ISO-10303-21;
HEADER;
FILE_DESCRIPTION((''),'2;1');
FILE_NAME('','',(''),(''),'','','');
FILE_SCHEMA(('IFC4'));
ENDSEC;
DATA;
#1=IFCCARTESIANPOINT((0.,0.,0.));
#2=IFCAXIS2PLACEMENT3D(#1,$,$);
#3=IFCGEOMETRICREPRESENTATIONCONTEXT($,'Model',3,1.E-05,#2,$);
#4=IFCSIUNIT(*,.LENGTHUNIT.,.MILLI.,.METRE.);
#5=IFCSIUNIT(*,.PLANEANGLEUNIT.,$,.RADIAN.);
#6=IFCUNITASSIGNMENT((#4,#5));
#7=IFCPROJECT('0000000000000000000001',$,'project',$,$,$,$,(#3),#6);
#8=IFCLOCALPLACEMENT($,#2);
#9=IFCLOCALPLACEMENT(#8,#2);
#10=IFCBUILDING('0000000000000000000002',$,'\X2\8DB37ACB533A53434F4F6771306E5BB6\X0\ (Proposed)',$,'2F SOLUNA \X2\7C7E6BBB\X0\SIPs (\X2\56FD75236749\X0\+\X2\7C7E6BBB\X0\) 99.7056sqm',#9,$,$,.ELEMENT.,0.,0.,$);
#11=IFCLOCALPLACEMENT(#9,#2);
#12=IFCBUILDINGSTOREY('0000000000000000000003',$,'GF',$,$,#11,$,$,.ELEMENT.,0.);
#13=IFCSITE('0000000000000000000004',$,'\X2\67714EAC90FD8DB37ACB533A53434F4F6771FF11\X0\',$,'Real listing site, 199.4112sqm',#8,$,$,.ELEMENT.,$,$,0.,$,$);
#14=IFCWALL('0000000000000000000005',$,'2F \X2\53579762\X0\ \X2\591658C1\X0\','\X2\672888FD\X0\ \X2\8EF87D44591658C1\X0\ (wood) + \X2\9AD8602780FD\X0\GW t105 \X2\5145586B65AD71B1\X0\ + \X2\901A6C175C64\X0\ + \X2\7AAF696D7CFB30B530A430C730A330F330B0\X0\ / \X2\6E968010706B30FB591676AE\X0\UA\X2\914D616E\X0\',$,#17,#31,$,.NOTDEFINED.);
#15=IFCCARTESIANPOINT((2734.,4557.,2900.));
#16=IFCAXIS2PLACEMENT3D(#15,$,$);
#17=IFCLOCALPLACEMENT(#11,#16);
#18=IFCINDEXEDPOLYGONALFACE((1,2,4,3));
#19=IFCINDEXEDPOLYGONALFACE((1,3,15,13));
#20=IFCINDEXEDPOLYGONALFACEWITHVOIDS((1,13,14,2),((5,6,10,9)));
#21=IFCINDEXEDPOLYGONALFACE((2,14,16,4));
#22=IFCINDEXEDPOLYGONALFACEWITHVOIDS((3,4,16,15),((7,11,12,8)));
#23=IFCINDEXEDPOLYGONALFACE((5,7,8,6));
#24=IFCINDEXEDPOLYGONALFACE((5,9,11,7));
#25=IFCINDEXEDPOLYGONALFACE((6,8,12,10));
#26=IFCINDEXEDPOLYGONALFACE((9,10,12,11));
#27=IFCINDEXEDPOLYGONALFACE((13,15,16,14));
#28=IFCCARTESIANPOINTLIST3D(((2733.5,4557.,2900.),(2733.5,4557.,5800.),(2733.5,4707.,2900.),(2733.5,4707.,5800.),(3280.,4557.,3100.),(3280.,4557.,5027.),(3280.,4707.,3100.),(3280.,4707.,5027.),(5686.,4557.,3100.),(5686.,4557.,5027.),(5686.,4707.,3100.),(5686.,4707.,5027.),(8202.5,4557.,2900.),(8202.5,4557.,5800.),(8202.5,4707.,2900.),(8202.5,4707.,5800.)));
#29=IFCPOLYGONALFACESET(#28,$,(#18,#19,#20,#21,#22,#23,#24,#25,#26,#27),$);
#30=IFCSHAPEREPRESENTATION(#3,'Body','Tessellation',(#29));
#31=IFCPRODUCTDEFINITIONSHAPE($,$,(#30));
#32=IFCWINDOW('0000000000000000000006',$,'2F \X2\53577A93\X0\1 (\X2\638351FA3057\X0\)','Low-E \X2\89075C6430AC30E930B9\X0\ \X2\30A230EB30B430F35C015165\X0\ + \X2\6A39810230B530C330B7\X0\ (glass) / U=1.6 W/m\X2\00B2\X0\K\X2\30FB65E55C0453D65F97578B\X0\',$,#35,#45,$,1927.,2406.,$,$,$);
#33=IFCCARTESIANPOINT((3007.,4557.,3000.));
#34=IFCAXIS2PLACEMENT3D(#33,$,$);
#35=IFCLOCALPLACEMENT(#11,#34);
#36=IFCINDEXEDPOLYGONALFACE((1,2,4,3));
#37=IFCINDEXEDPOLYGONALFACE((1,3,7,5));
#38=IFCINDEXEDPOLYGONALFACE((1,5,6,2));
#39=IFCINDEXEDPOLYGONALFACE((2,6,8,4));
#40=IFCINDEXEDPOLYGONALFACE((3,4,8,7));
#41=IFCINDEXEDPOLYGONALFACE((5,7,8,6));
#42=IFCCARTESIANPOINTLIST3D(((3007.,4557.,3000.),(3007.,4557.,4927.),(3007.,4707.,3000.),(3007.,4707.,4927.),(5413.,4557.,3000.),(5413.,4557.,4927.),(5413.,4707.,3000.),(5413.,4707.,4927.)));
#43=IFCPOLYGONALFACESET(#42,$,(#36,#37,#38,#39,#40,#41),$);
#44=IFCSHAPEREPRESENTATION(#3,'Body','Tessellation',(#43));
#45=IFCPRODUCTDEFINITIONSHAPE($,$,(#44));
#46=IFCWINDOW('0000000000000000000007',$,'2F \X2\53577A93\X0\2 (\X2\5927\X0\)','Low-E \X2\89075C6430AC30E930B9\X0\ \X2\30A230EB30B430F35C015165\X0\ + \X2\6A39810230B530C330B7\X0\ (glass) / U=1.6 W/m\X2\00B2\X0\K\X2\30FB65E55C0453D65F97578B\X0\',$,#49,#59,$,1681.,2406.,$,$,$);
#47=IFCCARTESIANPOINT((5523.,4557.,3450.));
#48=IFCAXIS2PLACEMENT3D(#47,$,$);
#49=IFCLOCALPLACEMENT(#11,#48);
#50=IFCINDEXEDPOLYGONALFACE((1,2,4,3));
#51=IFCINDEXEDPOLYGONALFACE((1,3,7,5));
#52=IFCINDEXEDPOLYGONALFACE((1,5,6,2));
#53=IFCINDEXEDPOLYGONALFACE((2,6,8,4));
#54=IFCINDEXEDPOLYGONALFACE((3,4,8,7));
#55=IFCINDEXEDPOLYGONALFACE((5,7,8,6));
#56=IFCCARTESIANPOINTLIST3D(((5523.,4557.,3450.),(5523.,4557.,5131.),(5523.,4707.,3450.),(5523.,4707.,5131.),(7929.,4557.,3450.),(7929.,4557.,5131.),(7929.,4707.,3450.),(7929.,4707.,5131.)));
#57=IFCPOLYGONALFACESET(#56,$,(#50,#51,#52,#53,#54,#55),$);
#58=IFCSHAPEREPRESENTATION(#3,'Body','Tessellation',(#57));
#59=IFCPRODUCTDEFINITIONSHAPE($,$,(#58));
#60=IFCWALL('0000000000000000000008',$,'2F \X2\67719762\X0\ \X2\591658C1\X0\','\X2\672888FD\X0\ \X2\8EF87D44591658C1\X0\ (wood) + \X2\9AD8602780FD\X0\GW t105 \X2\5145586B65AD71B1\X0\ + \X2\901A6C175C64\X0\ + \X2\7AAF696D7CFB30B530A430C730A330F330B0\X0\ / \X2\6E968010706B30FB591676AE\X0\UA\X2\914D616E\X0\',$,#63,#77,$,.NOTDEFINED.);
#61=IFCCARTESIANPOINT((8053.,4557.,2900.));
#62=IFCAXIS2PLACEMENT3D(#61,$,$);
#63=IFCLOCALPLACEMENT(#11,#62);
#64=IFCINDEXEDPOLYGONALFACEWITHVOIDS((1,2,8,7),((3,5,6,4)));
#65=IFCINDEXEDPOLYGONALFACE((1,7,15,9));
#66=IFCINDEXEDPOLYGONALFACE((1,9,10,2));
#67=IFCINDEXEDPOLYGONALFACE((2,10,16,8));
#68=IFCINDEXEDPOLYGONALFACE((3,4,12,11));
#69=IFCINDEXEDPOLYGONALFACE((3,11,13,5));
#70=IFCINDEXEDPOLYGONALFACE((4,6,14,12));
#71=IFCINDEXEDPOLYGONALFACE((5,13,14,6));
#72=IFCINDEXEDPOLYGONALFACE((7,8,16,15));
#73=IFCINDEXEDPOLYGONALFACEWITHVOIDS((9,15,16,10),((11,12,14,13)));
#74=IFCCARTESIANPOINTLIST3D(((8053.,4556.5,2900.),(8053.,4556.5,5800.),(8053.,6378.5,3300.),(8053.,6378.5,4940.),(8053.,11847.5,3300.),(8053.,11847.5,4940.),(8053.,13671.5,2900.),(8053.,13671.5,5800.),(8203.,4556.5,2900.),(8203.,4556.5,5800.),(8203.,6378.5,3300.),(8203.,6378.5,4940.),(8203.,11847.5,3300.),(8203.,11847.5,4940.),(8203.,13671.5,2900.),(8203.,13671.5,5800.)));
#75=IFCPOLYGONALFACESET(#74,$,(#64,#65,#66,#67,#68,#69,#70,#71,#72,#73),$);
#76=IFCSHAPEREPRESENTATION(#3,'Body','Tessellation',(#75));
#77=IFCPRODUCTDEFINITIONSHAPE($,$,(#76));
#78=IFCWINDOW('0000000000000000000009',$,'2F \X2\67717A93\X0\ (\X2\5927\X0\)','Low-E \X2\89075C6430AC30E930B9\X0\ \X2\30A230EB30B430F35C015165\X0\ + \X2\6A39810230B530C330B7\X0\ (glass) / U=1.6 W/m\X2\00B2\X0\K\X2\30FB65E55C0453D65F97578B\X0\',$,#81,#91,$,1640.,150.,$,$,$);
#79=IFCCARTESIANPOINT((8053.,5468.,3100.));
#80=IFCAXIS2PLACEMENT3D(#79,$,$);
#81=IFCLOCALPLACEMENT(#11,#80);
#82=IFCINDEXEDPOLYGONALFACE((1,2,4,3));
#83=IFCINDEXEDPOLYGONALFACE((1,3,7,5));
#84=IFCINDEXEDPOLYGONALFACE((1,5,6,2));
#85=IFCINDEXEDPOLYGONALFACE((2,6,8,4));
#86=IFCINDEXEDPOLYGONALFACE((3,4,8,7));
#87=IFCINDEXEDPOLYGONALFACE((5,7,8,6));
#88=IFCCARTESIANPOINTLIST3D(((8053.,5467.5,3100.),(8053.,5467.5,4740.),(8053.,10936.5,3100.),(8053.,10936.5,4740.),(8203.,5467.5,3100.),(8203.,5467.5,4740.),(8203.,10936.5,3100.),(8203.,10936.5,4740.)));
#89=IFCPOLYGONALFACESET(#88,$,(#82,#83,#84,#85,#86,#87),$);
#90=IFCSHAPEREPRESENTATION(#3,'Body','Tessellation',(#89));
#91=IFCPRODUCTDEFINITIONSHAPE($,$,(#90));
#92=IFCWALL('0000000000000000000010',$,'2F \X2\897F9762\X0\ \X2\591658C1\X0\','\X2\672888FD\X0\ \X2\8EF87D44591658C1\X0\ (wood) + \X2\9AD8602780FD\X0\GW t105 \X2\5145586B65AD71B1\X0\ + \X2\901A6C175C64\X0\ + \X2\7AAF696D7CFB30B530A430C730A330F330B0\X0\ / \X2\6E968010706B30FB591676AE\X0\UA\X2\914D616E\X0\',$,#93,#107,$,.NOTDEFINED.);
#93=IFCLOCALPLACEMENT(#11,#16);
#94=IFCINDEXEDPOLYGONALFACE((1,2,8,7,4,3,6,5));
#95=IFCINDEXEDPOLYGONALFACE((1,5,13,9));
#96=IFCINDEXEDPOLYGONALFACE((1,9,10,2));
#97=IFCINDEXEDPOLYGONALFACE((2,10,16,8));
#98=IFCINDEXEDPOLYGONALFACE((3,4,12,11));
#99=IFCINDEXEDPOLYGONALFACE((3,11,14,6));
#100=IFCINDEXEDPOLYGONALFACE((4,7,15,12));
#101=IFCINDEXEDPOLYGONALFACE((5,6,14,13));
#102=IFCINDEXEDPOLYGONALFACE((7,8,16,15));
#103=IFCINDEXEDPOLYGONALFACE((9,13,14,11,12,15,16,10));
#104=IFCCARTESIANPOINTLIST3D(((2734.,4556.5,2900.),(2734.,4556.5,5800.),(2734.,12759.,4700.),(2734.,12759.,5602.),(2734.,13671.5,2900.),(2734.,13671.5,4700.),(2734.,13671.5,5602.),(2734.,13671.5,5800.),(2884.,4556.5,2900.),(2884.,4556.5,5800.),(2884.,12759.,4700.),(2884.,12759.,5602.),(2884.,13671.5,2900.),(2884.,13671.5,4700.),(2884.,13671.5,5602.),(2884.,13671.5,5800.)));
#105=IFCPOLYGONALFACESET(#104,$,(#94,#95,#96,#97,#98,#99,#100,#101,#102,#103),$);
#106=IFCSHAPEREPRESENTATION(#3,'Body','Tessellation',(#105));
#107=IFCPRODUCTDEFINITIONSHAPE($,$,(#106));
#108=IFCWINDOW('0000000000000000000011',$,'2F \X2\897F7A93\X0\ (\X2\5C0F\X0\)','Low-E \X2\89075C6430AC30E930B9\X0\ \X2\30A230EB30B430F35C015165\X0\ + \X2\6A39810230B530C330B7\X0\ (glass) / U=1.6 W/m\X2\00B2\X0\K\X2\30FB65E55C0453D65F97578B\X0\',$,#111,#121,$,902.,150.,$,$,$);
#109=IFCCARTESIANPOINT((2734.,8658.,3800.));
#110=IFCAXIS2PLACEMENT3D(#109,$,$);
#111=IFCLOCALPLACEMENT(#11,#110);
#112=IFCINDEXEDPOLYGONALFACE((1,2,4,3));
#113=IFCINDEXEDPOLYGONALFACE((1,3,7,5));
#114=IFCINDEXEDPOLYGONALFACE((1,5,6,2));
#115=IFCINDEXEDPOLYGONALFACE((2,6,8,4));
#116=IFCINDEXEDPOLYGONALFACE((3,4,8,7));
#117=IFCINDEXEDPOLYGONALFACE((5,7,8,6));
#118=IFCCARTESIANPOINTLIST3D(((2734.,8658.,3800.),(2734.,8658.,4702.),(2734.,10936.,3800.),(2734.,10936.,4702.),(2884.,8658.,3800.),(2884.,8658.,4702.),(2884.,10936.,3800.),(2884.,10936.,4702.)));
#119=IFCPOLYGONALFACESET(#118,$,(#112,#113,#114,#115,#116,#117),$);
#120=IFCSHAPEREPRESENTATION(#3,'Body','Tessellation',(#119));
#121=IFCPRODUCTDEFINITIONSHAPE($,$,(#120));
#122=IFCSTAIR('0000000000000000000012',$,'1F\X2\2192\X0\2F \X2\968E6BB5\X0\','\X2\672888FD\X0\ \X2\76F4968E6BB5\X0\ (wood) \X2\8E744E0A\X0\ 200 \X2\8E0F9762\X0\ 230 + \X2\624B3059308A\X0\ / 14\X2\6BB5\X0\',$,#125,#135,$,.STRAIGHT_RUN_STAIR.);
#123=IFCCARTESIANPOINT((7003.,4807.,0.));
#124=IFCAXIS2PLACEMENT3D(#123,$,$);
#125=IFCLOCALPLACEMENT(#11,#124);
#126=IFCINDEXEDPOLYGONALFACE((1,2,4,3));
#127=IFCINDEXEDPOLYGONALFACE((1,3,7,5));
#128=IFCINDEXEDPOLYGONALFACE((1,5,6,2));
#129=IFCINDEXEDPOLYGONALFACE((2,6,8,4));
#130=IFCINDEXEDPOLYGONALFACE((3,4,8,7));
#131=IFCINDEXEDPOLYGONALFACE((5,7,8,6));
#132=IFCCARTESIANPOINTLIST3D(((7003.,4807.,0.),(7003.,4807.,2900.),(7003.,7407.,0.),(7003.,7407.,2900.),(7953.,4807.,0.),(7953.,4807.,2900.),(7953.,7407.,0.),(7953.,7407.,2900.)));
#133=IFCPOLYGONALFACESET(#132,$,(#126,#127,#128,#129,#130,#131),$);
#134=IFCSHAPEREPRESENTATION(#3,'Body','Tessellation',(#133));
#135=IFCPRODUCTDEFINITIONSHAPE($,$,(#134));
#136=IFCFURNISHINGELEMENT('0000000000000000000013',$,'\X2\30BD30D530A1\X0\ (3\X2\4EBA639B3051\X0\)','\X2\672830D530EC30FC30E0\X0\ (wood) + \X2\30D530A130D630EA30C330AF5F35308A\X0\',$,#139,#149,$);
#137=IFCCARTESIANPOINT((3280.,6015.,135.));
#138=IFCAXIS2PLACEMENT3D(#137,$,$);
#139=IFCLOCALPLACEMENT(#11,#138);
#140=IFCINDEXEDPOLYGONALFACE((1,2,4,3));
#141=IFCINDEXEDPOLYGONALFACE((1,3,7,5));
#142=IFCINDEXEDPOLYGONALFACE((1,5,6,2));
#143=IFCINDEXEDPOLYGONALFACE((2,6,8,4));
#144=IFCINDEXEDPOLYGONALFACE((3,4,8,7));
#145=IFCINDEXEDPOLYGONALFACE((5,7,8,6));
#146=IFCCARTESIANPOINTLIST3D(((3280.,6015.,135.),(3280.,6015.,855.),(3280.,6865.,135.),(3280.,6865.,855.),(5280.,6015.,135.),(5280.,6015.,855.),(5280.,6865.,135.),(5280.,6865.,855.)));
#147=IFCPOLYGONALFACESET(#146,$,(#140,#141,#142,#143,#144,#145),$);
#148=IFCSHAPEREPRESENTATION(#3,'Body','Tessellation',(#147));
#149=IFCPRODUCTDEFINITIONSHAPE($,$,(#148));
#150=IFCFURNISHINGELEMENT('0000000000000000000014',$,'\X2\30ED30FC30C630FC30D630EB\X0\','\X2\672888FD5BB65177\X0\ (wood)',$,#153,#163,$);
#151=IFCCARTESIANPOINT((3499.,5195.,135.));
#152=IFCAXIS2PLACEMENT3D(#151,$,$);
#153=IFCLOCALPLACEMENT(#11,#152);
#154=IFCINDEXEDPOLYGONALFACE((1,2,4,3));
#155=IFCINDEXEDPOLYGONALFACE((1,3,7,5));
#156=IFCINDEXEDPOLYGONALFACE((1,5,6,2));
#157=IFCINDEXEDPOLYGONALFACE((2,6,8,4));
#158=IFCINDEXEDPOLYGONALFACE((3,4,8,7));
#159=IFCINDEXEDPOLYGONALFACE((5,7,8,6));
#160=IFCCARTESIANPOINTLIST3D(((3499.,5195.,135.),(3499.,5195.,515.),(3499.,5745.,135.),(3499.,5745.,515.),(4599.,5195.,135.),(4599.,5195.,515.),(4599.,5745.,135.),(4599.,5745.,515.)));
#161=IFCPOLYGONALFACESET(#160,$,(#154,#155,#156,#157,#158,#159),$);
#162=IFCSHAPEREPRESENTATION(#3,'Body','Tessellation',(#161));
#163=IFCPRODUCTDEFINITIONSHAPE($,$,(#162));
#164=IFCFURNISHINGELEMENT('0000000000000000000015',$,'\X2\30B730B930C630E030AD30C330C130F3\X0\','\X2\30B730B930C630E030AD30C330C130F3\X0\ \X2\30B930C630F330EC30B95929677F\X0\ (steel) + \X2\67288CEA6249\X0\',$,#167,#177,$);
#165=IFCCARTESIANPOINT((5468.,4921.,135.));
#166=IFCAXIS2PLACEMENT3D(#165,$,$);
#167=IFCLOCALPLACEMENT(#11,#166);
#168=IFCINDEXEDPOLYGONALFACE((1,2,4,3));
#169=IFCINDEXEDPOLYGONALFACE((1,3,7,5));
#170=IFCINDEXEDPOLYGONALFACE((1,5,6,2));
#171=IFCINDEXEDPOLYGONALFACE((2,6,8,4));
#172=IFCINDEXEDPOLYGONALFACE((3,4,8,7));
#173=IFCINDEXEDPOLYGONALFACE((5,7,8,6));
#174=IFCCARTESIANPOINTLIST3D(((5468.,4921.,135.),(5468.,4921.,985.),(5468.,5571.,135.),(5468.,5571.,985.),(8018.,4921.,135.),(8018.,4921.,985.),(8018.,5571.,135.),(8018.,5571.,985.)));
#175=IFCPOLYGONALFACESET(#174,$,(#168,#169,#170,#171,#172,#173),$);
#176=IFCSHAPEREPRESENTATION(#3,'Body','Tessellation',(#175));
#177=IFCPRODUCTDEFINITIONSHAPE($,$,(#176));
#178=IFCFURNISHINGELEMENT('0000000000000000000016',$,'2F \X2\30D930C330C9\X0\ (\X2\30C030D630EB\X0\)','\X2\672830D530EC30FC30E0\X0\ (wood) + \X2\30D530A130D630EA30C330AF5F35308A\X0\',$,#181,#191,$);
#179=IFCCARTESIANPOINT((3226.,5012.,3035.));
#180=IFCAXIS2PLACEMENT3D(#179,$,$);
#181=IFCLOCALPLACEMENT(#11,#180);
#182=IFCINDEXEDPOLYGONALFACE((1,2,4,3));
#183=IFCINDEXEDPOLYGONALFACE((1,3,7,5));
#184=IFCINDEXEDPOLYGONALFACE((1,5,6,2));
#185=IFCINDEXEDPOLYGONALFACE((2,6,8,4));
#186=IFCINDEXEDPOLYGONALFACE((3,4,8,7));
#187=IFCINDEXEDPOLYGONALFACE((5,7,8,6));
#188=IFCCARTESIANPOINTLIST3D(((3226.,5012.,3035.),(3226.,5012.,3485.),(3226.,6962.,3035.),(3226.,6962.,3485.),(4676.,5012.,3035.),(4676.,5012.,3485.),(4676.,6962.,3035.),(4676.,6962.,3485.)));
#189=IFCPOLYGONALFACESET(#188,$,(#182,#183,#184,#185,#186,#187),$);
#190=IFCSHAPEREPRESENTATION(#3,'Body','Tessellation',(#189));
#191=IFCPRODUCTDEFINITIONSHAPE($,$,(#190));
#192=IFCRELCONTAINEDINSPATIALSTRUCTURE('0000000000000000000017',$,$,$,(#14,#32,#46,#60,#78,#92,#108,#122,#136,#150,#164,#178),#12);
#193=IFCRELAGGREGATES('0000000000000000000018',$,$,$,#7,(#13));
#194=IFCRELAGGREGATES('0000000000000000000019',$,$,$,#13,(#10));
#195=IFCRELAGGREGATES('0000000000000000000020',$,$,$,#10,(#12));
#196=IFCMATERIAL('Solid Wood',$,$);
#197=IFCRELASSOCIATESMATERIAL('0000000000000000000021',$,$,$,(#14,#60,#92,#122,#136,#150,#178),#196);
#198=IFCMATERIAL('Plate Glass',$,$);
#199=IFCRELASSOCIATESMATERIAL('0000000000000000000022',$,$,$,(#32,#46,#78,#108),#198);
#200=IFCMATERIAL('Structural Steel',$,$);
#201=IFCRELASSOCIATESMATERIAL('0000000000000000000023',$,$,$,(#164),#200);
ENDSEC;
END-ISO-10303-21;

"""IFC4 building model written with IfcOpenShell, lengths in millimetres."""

from ifc_helpers import new_model, si_unit, frame, frame_2d, origin, place, context, project, spatial, rectangle, extrude, material, element, fill, save


model = new_model("IFC4")

# Units and contexts
model_context = context("Model", 3, precision=1e-05, world=origin())
ifc_project = project(units=[si_unit("LENGTHUNIT", "METRE", prefix="MILLI"), si_unit("PLANEANGLEUNIT", "RADIAN")], contexts=[model_context])

# Site, building, storey
site_placement = place(None, origin())
site = spatial("IfcSite", under=ifc_project, at=site_placement, Name="東京都足立区千住東１", ObjectType="Real listing site, 199.4112sqm", CompositionType="ELEMENT", RefElevation=0.0)
building_placement = place(site_placement, origin())
building = spatial("IfcBuilding", under=site, at=building_placement, Name="足立区千住東の家 (Proposed)", ObjectType="2F SOLUNA 籾殻SIPs (国産杉+籾殻) 99.7056sqm", CompositionType="ELEMENT", ElevationOfRefHeight=0.0, ElevationOfTerrain=0.0)
storey_placement = place(building_placement, origin())
storey = spatial("IfcBuildingStorey", under=building, at=storey_placement, Name="GF", CompositionType="ELEMENT", Elevation=0.0)

# Shared definitions
ifc_material_1 = material(Name="Solid Wood")

# Shared definitions
ifc_material_2 = material(Name="Plate Glass")

# Wall, openings, windows
wall_1_placement = place(storey_placement, frame((2734.0, 4557.0, 2900.0)))
wall_1 = element("IfcWall", 1, at=wall_1_placement, inside=storey, material=ifc_material_1, Name="2F 南面 外壁", Description="木製 軸組外壁 (wood) + 高性能GW t105 充填断熱 + 通気層 + 窯業系サイディング / 準耐火・外皮UA配慮", PredefinedType="NOTDEFINED", context=model_context, shape_type="SweptSolid", body=[
    extrude(rectangle(XDim=5469.0, YDim=150.0, at=frame_2d((2734.0, 75.0))), frame((2734.0, 4557.0, 2900.0)), (0.0, 0.0, 1.0), 2900.0),
])
opening_1_placement = place(storey_placement, frame((3007.0, 4557.0, 3000.0)))
opening_1 = element("IfcOpeningElement", 2, at=opening_1_placement, cuts=wall_1, PredefinedType="NOTDEFINED", context=model_context, shape_type="SweptSolid", body=[
    extrude(rectangle(XDim=2406.0, YDim=150.0, at=frame_2d((1203.0, 75.0))), frame((3007.0, 4557.0, 3000.0)), (0.0, 0.0, 1.0), 1927.0),
])
opening_2_placement = place(storey_placement, frame((5523.0, 4557.0, 3450.0)))
opening_2 = element("IfcOpeningElement", 3, at=opening_2_placement, cuts=wall_1, PredefinedType="NOTDEFINED", context=model_context, shape_type="SweptSolid", body=[
    extrude(rectangle(XDim=2406.0, YDim=150.0, at=frame_2d((1203.0, 75.0))), frame((5523.0, 4557.0, 3450.0)), (0.0, 0.0, 1.0), 1681.0),
])
window_1_placement = place(storey_placement, frame((3007.0, 4557.0, 3000.0)))
window_1 = element("IfcWindow", 4, at=window_1_placement, inside=storey, material=ifc_material_2, Name="2F 南窓1 (掃出し)", Description="Low-E 複層ガラス アルゴン封入 + 樹脂サッシ (glass) / U=1.6 W/m²K・日射取得型", OverallHeight=1927.0, OverallWidth=2406.0, context=model_context, shape_type="SweptSolid", body=[
    extrude(rectangle(XDim=2406.0, YDim=150.0, at=frame_2d((1203.0, 75.0))), frame((3007.0, 4557.0, 3000.0)), (0.0, 0.0, 1.0), 1927.0),
])
fill(opening_1, window_1)
window_2_placement = place(storey_placement, frame((5523.0, 4557.0, 3450.0)))
window_2 = element("IfcWindow", 5, at=window_2_placement, inside=storey, material=ifc_material_2, Name="2F 南窓2 (大)", Description="Low-E 複層ガラス アルゴン封入 + 樹脂サッシ (glass) / U=1.6 W/m²K・日射取得型", OverallHeight=1681.0, OverallWidth=2406.0, context=model_context, shape_type="SweptSolid", body=[
    extrude(rectangle(XDim=2406.0, YDim=150.0, at=frame_2d((1203.0, 75.0))), frame((5523.0, 4557.0, 3450.0)), (0.0, 0.0, 1.0), 1681.0),
])
fill(opening_2, window_2)

# Walls, openings, windows
wall_2_placement = place(storey_placement, frame((8053.0, 4557.0, 2900.0)))
wall_2 = element("IfcWall", 6, at=wall_2_placement, inside=storey, material=ifc_material_1, Name="2F 東面 外壁", Description="木製 軸組外壁 (wood) + 高性能GW t105 充填断熱 + 通気層 + 窯業系サイディング / 準耐火・外皮UA配慮", PredefinedType="NOTDEFINED", context=model_context, shape_type="SweptSolid", body=[
    extrude(rectangle(XDim=150.0, YDim=9115.0, at=frame_2d((75.0, 4557.0))), frame((8053.0, 4557.0, 2900.0)), (0.0, 0.0, 1.0), 2900.0),
])
opening_3_placement = place(storey_placement, frame((8053.0, 5468.0, 3100.0)))
opening_3 = element("IfcOpeningElement", 7, at=opening_3_placement, cuts=wall_2, PredefinedType="NOTDEFINED", context=model_context, shape_type="SweptSolid", body=[
    extrude(rectangle(XDim=150.0, YDim=5469.0, at=frame_2d((75.0, 2734.0))), frame((8053.0, 5468.0, 3100.0)), (0.0, 0.0, 1.0), 1640.0),
])
window_3_placement = place(storey_placement, frame((8053.0, 5468.0, 3100.0)))
window_3 = element("IfcWindow", 8, at=window_3_placement, inside=storey, material=ifc_material_2, Name="2F 東窓 (大)", Description="Low-E 複層ガラス アルゴン封入 + 樹脂サッシ (glass) / U=1.6 W/m²K・日射取得型", OverallHeight=1640.0, OverallWidth=150.0, context=model_context, shape_type="SweptSolid", body=[
    extrude(rectangle(XDim=150.0, YDim=5469.0, at=frame_2d((75.0, 2734.0))), frame((8053.0, 5468.0, 3100.0)), (0.0, 0.0, 1.0), 1640.0),
])
fill(opening_3, window_3)
wall_3_placement = place(storey_placement, frame((2734.0, 4557.0, 2900.0)))
wall_3 = element("IfcWall", 9, at=wall_3_placement, inside=storey, material=ifc_material_1, Name="2F 西面 外壁", Description="木製 軸組外壁 (wood) + 高性能GW t105 充填断熱 + 通気層 + 窯業系サイディング / 準耐火・外皮UA配慮", PredefinedType="NOTDEFINED", context=model_context, shape_type="SweptSolid", body=[
    extrude(rectangle(XDim=150.0, YDim=9115.0, at=frame_2d((75.0, 4557.0))), frame((2734.0, 4557.0, 2900.0)), (0.0, 0.0, 1.0), 2900.0),
])
opening_4_placement = place(storey_placement, frame((2734.0, 8658.0, 3800.0)))
opening_4 = element("IfcOpeningElement", 10, at=opening_4_placement, cuts=wall_3, PredefinedType="NOTDEFINED", context=model_context, shape_type="SweptSolid", body=[
    extrude(rectangle(XDim=150.0, YDim=2278.0, at=frame_2d((75.0, 1139.0))), frame((2734.0, 8658.0, 3800.0)), (0.0, 0.0, 1.0), 902.0),
])
window_4_placement = place(storey_placement, frame((2734.0, 8658.0, 3800.0)))
window_4 = element("IfcWindow", 11, at=window_4_placement, inside=storey, material=ifc_material_2, Name="2F 西窓 (小)", Description="Low-E 複層ガラス アルゴン封入 + 樹脂サッシ (glass) / U=1.6 W/m²K・日射取得型", OverallHeight=902.0, OverallWidth=150.0, context=model_context, shape_type="SweptSolid", body=[
    extrude(rectangle(XDim=150.0, YDim=2278.0, at=frame_2d((75.0, 1139.0))), frame((2734.0, 8658.0, 3800.0)), (0.0, 0.0, 1.0), 902.0),
])
fill(opening_4, window_4)

# Stair
stair_placement = place(storey_placement, frame((7003.0, 4807.0, 0.0)))
element("IfcStair", 12, at=stair_placement, inside=storey, material=ifc_material_1, Name="1F→2F 階段", Description="木製 直階段 (wood) 蹴上 200 踏面 230 + 手すり / 14段", PredefinedType="STRAIGHT_RUN_STAIR", context=model_context, shape_type="SweptSolid", body=[
    extrude(rectangle(XDim=950.0, YDim=2600.0, at=frame_2d((475.0, 1300.0))), frame((7003.0, 4807.0, 0.0)), (0.0, 0.0, 1.0), 2900.0),
])

# Shared definitions
ifc_material_3 = material(Name="Structural Steel")

# Furnishing elements
furnishing_1_placement = place(storey_placement, frame((3280.0, 6015.0, 135.0)))
element("IfcFurnishingElement", 13, at=furnishing_1_placement, inside=storey, material=ifc_material_1, Name="ソファ (3人掛け)", Description="木フレーム (wood) + ファブリック張り", context=model_context, shape_type="SweptSolid", body=[
    extrude(rectangle(XDim=2000.0, YDim=850.0, at=frame_2d((1000.0, 425.0))), frame((3280.0, 6015.0, 135.0)), (0.0, 0.0, 1.0), 720.0),
])
furnishing_2_placement = place(storey_placement, frame((3499.0, 5195.0, 135.0)))
element("IfcFurnishingElement", 14, at=furnishing_2_placement, inside=storey, material=ifc_material_1, Name="ローテーブル", Description="木製家具 (wood)", context=model_context, shape_type="SweptSolid", body=[
    extrude(rectangle(XDim=1100.0, YDim=550.0, at=frame_2d((550.0, 275.0))), frame((3499.0, 5195.0, 135.0)), (0.0, 0.0, 1.0), 380.0),
])
furnishing_3_placement = place(storey_placement, frame((5468.0, 4921.0, 135.0)))
element("IfcFurnishingElement", 15, at=furnishing_3_placement, inside=storey, material=ifc_material_3, Name="システムキッチン", Description="システムキッチン ステンレス天板 (steel) + 木質扉", context=model_context, shape_type="SweptSolid", body=[
    extrude(rectangle(XDim=2550.0, YDim=650.0, at=frame_2d((1275.0, 325.0))), frame((5468.0, 4921.0, 135.0)), (0.0, 0.0, 1.0), 850.0),
])
furnishing_4_placement = place(storey_placement, frame((3226.0, 5012.0, 3035.0)))
element("IfcFurnishingElement", 16, at=furnishing_4_placement, inside=storey, material=ifc_material_1, Name="2F ベッド (ダブル)", Description="木フレーム (wood) + ファブリック張り", context=model_context, shape_type="SweptSolid", body=[
    extrude(rectangle(XDim=1450.0, YDim=1950.0, at=frame_2d((725.0, 975.0))), frame((3226.0, 5012.0, 3035.0)), (0.0, 0.0, 1.0), 450.0),
])

save(model, "model.ifc")
